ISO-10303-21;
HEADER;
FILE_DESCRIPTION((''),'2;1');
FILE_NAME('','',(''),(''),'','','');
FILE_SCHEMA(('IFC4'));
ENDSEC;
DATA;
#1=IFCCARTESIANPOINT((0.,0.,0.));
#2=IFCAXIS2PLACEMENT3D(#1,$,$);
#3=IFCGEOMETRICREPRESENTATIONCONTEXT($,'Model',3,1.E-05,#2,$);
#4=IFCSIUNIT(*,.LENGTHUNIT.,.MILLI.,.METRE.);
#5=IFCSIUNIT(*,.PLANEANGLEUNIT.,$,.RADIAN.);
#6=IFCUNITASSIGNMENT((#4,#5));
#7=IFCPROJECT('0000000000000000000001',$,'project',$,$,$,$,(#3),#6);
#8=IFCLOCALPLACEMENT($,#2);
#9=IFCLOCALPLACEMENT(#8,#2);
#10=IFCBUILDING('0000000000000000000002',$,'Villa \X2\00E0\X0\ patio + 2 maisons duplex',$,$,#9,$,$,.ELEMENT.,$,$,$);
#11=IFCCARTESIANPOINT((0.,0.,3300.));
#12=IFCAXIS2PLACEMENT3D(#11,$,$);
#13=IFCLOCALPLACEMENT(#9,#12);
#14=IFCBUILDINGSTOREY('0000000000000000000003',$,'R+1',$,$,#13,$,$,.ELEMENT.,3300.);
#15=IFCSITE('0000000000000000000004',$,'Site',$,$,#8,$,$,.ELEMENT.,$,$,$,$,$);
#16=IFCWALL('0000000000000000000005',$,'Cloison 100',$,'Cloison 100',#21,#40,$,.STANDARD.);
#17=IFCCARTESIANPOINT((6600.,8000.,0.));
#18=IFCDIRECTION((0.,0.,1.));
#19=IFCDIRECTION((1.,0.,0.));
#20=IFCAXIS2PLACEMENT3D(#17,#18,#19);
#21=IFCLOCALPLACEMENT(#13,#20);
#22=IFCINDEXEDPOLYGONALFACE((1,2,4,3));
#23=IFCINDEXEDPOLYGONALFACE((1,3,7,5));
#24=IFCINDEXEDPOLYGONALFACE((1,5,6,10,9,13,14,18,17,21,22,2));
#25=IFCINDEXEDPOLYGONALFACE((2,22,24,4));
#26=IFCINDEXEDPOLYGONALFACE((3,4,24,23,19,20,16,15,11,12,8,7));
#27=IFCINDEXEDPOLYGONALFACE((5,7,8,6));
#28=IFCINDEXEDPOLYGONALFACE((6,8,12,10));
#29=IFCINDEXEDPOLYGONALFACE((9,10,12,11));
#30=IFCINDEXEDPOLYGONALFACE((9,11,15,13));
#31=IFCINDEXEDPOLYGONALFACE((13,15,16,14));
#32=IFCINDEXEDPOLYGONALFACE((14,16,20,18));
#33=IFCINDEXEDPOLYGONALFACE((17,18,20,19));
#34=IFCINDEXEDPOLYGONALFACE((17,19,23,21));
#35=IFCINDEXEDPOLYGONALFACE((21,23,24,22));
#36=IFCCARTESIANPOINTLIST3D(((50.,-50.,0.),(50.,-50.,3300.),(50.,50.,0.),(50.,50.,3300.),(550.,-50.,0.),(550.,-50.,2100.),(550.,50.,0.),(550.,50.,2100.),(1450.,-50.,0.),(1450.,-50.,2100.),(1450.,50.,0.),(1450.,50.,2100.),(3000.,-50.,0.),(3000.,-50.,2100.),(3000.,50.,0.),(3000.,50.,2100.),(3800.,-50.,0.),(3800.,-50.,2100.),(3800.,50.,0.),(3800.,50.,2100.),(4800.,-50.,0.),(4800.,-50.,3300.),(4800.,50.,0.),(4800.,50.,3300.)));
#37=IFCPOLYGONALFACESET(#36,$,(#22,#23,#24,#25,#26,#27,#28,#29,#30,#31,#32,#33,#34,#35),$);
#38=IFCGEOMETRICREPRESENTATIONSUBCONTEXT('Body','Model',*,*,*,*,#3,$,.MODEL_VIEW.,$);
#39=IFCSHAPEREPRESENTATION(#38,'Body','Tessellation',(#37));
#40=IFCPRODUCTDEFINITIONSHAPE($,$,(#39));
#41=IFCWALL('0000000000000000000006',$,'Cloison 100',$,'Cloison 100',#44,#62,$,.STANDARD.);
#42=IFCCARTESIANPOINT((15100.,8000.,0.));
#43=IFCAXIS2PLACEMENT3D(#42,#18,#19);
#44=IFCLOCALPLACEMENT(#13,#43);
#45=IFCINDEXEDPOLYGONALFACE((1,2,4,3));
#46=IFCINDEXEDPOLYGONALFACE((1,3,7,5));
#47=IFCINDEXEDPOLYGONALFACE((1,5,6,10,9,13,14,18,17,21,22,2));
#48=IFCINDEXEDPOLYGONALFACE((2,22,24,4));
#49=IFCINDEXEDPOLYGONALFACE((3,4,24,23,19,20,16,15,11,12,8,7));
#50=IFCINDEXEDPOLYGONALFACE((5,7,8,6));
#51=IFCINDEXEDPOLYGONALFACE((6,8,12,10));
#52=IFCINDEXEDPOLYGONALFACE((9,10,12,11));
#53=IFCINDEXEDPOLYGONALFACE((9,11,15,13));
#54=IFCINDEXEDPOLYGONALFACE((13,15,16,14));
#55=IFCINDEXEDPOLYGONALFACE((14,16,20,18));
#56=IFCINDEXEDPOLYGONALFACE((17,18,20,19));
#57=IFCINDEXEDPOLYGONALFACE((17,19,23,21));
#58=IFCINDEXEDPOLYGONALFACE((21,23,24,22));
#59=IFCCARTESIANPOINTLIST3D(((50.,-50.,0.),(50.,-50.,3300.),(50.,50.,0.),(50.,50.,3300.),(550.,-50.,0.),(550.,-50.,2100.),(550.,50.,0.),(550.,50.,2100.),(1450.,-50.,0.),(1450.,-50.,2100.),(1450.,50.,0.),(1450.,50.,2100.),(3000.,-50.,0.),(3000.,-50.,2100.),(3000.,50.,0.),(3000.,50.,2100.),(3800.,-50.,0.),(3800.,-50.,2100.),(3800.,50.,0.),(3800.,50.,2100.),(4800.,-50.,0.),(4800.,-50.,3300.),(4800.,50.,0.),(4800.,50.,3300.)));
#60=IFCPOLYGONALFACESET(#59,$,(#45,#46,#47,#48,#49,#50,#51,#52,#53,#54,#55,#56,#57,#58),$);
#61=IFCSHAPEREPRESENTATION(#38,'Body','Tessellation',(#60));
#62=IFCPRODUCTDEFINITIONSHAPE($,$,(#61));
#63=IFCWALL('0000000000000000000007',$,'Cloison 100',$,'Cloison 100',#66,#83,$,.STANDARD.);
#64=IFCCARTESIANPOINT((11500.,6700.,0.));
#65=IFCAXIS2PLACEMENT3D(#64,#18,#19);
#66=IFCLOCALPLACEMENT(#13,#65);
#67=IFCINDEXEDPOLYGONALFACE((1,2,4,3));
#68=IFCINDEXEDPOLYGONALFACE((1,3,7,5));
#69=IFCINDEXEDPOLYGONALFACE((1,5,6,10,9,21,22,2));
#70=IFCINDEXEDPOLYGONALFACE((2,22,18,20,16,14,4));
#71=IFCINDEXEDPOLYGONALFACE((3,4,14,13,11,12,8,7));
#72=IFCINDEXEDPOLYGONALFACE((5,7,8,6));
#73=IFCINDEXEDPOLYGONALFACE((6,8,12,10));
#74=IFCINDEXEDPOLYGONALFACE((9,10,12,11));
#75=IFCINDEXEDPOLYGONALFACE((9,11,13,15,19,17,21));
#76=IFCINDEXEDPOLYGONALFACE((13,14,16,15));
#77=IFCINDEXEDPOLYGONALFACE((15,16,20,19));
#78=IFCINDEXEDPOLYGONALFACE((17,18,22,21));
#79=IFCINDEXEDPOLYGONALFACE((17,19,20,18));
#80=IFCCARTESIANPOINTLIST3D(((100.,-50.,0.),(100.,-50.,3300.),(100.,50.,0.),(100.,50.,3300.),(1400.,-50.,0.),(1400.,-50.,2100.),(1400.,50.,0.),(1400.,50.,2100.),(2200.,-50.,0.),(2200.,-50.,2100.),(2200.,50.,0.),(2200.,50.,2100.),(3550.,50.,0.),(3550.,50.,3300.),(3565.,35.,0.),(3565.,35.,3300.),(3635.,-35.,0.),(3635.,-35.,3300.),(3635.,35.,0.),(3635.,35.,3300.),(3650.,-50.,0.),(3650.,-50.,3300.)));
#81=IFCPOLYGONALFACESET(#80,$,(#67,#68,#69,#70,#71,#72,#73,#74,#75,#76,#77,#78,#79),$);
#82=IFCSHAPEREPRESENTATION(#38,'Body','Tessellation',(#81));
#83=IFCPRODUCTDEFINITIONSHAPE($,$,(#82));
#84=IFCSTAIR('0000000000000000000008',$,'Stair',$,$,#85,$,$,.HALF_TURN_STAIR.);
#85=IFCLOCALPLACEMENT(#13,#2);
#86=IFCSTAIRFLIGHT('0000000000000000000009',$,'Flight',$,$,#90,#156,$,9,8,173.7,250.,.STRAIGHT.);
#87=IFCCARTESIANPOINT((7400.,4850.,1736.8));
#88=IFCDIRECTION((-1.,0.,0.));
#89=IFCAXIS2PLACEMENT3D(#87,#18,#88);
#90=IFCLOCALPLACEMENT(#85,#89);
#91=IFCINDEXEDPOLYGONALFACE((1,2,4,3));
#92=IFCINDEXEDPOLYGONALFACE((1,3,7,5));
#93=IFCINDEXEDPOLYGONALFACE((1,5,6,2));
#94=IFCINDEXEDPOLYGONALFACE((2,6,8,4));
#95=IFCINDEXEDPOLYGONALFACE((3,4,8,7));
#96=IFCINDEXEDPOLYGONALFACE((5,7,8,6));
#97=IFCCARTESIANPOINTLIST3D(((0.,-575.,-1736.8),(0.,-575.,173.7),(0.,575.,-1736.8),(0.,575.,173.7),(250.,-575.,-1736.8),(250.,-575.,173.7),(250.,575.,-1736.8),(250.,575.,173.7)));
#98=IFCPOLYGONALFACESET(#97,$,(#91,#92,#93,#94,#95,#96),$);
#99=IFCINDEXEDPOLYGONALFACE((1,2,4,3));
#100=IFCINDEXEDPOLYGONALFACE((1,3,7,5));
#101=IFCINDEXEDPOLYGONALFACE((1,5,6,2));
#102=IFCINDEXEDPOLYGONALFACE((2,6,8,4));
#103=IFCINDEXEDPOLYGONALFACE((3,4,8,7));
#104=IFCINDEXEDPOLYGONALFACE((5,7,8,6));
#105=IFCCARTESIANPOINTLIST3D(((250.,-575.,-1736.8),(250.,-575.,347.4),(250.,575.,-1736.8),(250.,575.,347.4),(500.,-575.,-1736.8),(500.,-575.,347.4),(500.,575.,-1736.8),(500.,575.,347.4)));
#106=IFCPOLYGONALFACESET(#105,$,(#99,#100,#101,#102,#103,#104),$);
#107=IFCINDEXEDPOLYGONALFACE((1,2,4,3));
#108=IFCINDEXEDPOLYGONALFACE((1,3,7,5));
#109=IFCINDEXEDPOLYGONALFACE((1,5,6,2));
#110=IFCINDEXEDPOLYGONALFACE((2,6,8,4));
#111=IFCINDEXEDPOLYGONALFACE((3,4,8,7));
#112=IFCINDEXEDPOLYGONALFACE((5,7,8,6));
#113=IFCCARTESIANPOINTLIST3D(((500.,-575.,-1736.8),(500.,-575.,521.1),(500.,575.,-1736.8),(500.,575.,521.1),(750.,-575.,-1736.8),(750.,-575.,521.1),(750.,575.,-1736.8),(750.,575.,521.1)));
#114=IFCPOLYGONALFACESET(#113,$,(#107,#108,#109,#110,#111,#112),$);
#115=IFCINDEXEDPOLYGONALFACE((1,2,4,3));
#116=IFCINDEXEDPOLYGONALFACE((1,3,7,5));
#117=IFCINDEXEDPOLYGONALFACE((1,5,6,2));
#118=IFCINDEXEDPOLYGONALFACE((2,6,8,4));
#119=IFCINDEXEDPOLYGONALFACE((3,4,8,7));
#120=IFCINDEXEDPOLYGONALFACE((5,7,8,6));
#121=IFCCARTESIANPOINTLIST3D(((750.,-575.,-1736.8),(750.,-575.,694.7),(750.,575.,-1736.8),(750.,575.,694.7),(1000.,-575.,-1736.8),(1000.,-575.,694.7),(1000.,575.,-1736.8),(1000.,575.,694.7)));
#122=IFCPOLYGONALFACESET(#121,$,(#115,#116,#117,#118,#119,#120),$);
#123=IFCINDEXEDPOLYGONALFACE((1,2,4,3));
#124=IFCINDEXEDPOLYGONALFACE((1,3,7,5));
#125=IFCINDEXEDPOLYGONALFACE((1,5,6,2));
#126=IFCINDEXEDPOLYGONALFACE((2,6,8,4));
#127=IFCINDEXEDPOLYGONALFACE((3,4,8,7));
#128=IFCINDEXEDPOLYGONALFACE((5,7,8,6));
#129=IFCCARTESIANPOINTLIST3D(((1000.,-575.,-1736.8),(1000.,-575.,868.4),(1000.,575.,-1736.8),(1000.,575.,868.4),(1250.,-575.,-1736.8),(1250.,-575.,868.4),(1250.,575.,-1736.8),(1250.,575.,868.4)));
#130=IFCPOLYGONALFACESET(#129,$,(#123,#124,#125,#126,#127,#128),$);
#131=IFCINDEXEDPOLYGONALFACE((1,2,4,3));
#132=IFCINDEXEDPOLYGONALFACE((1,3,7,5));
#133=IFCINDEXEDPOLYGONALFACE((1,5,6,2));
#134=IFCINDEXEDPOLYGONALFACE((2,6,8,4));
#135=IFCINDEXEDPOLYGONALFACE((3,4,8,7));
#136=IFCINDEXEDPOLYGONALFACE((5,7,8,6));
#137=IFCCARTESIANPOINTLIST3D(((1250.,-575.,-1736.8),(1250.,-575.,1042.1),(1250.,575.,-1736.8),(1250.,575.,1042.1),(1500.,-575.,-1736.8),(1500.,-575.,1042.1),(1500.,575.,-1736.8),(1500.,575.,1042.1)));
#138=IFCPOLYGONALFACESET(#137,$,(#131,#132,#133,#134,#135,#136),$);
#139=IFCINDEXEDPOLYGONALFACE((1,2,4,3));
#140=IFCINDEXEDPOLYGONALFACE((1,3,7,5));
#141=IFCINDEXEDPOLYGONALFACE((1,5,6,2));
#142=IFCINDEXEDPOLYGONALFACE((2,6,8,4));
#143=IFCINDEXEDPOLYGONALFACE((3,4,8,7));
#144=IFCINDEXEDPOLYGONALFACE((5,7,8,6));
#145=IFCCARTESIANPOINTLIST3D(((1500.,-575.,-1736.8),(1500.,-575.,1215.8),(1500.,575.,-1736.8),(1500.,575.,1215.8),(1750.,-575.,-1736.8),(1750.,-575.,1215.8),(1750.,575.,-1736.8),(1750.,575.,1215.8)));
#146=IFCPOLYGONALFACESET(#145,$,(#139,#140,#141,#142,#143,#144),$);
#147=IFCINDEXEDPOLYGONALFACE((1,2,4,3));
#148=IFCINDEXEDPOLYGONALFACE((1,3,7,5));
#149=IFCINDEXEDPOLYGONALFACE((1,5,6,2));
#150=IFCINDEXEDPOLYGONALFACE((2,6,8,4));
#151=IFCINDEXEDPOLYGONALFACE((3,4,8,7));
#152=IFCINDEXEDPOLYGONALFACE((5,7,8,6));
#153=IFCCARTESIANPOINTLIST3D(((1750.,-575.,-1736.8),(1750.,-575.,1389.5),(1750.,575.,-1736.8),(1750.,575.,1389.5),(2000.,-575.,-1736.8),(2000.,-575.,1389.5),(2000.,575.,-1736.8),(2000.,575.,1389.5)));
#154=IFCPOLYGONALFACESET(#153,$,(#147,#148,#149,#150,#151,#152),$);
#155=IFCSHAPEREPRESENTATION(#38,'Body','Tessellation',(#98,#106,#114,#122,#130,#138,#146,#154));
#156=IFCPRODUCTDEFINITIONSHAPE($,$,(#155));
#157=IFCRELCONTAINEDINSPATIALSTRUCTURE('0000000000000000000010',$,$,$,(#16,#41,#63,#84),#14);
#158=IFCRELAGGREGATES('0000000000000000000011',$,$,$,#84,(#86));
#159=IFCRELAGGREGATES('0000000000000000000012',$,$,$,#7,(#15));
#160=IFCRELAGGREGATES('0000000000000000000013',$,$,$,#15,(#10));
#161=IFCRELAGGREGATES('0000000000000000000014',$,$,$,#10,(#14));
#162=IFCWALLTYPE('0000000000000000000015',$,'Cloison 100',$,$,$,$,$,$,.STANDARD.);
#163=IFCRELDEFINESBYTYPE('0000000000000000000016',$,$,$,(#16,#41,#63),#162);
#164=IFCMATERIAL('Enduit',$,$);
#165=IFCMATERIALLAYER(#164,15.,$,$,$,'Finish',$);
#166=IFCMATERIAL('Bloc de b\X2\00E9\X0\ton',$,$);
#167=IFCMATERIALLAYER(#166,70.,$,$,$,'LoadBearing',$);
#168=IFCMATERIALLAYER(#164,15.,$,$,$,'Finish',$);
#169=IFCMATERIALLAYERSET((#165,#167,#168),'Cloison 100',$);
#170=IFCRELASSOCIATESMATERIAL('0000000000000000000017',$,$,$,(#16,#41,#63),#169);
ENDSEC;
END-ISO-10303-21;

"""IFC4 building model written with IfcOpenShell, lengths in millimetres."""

from ifc_helpers import new_model, si_unit, frame, frame_2d, origin, place, context, subcontext, project, spatial, polyline, rectangle, outline, extrude, material, layer, layer_set, layer_usage, type_object, element, aggregate, save


model = new_model("IFC4")

# Units and contexts
model_context = context("Model", 3, precision=1e-05, world=origin())
body_context = subcontext(model_context, "Body", "Model", "MODEL_VIEW")
ifc_project = project(units=[si_unit("LENGTHUNIT", "METRE", prefix="MILLI"), si_unit("PLANEANGLEUNIT", "RADIAN")], contexts=[model_context])

# Site, building, storey
site_placement = place(None, origin())
site = spatial("IfcSite", under=ifc_project, at=site_placement, Name="Site", CompositionType="ELEMENT")
building_placement = place(site_placement, origin())
building = spatial("IfcBuilding", under=site, at=building_placement, Name="Villa à patio + 2 maisons duplex", CompositionType="ELEMENT")
storey_placement = place(building_placement, frame((0.0, 0.0, 3300.0)))
storey = spatial("IfcBuildingStorey", under=building, at=storey_placement, Name="R+1", CompositionType="ELEMENT", Elevation=3300.0)

# Walls, openings
ifc_material_1 = material(Name="Enduit")
ifc_layer_1 = layer(ifc_material_1, 15.0, Category="Finish")
ifc_material_2 = material(Name="Bloc de béton")
ifc_layer_2 = layer(ifc_material_2, 70.0, Category="LoadBearing")
ifc_layer_3 = layer(ifc_material_1, 15.0, Category="Finish")
ifc_layer_set_1 = layer_set([ifc_layer_1, ifc_layer_2, ifc_layer_3], Name="Cloison 100")
ifc_layer_usage_1 = layer_usage(ifc_layer_set_1, "AXIS2", "NEGATIVE", 50.0)
wall_type_1 = type_object("IfcWallType", Name="Cloison 100", PredefinedType="STANDARD")
wall_1_placement = place(storey_placement, frame((6600.0, 8000.0, 0.0), z_axis=(0.0, 0.0, 1.0), x_axis=(1.0, 0.0, 0.0)))
wall_1 = element("IfcWall", 1, at=wall_1_placement, inside=storey, type_object=wall_type_1, material=ifc_layer_usage_1, Name="Cloison 100", ObjectType="Cloison 100", PredefinedType="STANDARD", context=body_context, shape_type="SweptSolid", body=[
    extrude(outline(polyline([(50.0, -50.0), (50.0, 50.0), (4800.0, 50.0), (4800.0, -50.0), (50.0, -50.0)])), origin(), (0.0, 0.0, 1.0), 3300.0),
])
opening_1_placement = place(wall_1_placement, frame((550.0, 0.0, 0.0), z_axis=(0.0, 0.0, 1.0), x_axis=(1.0, 0.0, 0.0)))
element("IfcOpeningElement", 2, at=opening_1_placement, cuts=wall_1, PredefinedType="OPENING", context=body_context, shape_type="SweptSolid", body=[
    extrude(rectangle(XDim=900.0, YDim=120.0, at=frame_2d((450.0, 0.0))), origin(), (0.0, 0.0, 1.0), 2100.0),
])
opening_2_placement = place(wall_1_placement, frame((3000.0, 0.0, 0.0), z_axis=(0.0, 0.0, 1.0), x_axis=(1.0, 0.0, 0.0)))
element("IfcOpeningElement", 3, at=opening_2_placement, cuts=wall_1, PredefinedType="OPENING", context=body_context, shape_type="SweptSolid", body=[
    extrude(rectangle(XDim=800.0, YDim=120.0, at=frame_2d((400.0, 0.0))), origin(), (0.0, 0.0, 1.0), 2100.0),
])
wall_2_placement = place(storey_placement, frame((15100.0, 8000.0, 0.0), z_axis=(0.0, 0.0, 1.0), x_axis=(1.0, 0.0, 0.0)))
wall_2 = element("IfcWall", 4, at=wall_2_placement, inside=storey, type_object=wall_type_1, material=ifc_layer_usage_1, Name="Cloison 100", ObjectType="Cloison 100", PredefinedType="STANDARD", context=body_context, shape_type="SweptSolid", body=[
    extrude(outline(polyline([(50.0, -50.0), (50.0, 50.0), (4800.0, 50.0), (4800.0, -50.0), (50.0, -50.0)])), origin(), (0.0, 0.0, 1.0), 3300.0),
])
opening_3_placement = place(wall_2_placement, frame((550.0, 0.0, 0.0), z_axis=(0.0, 0.0, 1.0), x_axis=(1.0, 0.0, 0.0)))
element("IfcOpeningElement", 5, at=opening_3_placement, cuts=wall_2, PredefinedType="OPENING", context=body_context, shape_type="SweptSolid", body=[
    extrude(rectangle(XDim=900.0, YDim=120.0, at=frame_2d((450.0, 0.0))), origin(), (0.0, 0.0, 1.0), 2100.0),
])
opening_4_placement = place(wall_2_placement, frame((3000.0, 0.0, 0.0), z_axis=(0.0, 0.0, 1.0), x_axis=(1.0, 0.0, 0.0)))
element("IfcOpeningElement", 6, at=opening_4_placement, cuts=wall_2, PredefinedType="OPENING", context=body_context, shape_type="SweptSolid", body=[
    extrude(rectangle(XDim=800.0, YDim=120.0, at=frame_2d((400.0, 0.0))), origin(), (0.0, 0.0, 1.0), 2100.0),
])

# Wall, opening
wall_3_placement = place(storey_placement, frame((11500.0, 6700.0, 0.0), z_axis=(0.0, 0.0, 1.0), x_axis=(1.0, 0.0, 0.0)))
wall_3 = element("IfcWall", 7, at=wall_3_placement, inside=storey, type_object=wall_type_1, material=ifc_layer_usage_1, Name="Cloison 100", ObjectType="Cloison 100", PredefinedType="STANDARD", context=body_context, shape_type="SweptSolid", body=[
    extrude(outline(polyline([(100.0, -50.0), (100.0, 50.0), (3550.0, 50.0), (3565.0, 35.0), (3635.0, 35.0), (3635.0, -35.0), (3650.0, -50.0), (100.0, -50.0)])), origin(), (0.0, 0.0, 1.0), 3300.0),
])
opening_5_placement = place(wall_3_placement, frame((1400.0, 0.0, 0.0), z_axis=(0.0, 0.0, 1.0), x_axis=(1.0, 0.0, 0.0)))
element("IfcOpeningElement", 8, at=opening_5_placement, cuts=wall_3, PredefinedType="OPENING", context=body_context, shape_type="SweptSolid", body=[
    extrude(rectangle(XDim=800.0, YDim=120.0, at=frame_2d((400.0, 0.0))), origin(), (0.0, 0.0, 1.0), 2100.0),
])

# Stair, stair flight
stair_1_placement = place(storey_placement, origin())
stair_1 = element("IfcStair", 9, at=stair_1_placement, inside=storey, Name="Stair", PredefinedType="HALF_TURN_STAIR")
stair_flight_1_placement = place(stair_1_placement, frame((7400.0, 4850.0, 1736.8), z_axis=(0.0, 0.0, 1.0), x_axis=(-1.0, 0.0, 0.0)))
stair_flight_1 = element("IfcStairFlight", 10, at=stair_flight_1_placement, Name="Flight", NumberOfRisers=9, NumberOfTreads=8, PredefinedType="STRAIGHT", RiserHeight=173.7, TreadLength=250.0, context=body_context, shape_type="SweptSolid", body=[
    extrude(rectangle(XDim=250.0, YDim=1150.0, at=frame_2d((125.0, 0.0))), frame((0.0, 0.0, -1736.8)), (0.0, 0.0, 1.0), 1910.5),
    extrude(rectangle(XDim=250.0, YDim=1150.0, at=frame_2d((375.0, 0.0))), frame((0.0, 0.0, -1736.8)), (0.0, 0.0, 1.0), 2084.2),
    extrude(rectangle(XDim=250.0, YDim=1150.0, at=frame_2d((625.0, 0.0))), frame((0.0, 0.0, -1736.8)), (0.0, 0.0, 1.0), 2257.9),
    extrude(rectangle(XDim=250.0, YDim=1150.0, at=frame_2d((875.0, 0.0))), frame((0.0, 0.0, -1736.8)), (0.0, 0.0, 1.0), 2431.6),
    extrude(rectangle(XDim=250.0, YDim=1150.0, at=frame_2d((1125.0, 0.0))), frame((0.0, 0.0, -1736.8)), (0.0, 0.0, 1.0), 2605.3),
    extrude(rectangle(XDim=250.0, YDim=1150.0, at=frame_2d((1375.0, 0.0))), frame((0.0, 0.0, -1736.8)), (0.0, 0.0, 1.0), 2778.9),
    extrude(rectangle(XDim=250.0, YDim=1150.0, at=frame_2d((1625.0, 0.0))), frame((0.0, 0.0, -1736.8)), (0.0, 0.0, 1.0), 2952.6),
    extrude(rectangle(XDim=250.0, YDim=1150.0, at=frame_2d((1875.0, 0.0))), frame((0.0, 0.0, -1736.8)), (0.0, 0.0, 1.0), 3126.3),
])
aggregate(stair_1, [stair_flight_1])

save(model, "model.ifc")
